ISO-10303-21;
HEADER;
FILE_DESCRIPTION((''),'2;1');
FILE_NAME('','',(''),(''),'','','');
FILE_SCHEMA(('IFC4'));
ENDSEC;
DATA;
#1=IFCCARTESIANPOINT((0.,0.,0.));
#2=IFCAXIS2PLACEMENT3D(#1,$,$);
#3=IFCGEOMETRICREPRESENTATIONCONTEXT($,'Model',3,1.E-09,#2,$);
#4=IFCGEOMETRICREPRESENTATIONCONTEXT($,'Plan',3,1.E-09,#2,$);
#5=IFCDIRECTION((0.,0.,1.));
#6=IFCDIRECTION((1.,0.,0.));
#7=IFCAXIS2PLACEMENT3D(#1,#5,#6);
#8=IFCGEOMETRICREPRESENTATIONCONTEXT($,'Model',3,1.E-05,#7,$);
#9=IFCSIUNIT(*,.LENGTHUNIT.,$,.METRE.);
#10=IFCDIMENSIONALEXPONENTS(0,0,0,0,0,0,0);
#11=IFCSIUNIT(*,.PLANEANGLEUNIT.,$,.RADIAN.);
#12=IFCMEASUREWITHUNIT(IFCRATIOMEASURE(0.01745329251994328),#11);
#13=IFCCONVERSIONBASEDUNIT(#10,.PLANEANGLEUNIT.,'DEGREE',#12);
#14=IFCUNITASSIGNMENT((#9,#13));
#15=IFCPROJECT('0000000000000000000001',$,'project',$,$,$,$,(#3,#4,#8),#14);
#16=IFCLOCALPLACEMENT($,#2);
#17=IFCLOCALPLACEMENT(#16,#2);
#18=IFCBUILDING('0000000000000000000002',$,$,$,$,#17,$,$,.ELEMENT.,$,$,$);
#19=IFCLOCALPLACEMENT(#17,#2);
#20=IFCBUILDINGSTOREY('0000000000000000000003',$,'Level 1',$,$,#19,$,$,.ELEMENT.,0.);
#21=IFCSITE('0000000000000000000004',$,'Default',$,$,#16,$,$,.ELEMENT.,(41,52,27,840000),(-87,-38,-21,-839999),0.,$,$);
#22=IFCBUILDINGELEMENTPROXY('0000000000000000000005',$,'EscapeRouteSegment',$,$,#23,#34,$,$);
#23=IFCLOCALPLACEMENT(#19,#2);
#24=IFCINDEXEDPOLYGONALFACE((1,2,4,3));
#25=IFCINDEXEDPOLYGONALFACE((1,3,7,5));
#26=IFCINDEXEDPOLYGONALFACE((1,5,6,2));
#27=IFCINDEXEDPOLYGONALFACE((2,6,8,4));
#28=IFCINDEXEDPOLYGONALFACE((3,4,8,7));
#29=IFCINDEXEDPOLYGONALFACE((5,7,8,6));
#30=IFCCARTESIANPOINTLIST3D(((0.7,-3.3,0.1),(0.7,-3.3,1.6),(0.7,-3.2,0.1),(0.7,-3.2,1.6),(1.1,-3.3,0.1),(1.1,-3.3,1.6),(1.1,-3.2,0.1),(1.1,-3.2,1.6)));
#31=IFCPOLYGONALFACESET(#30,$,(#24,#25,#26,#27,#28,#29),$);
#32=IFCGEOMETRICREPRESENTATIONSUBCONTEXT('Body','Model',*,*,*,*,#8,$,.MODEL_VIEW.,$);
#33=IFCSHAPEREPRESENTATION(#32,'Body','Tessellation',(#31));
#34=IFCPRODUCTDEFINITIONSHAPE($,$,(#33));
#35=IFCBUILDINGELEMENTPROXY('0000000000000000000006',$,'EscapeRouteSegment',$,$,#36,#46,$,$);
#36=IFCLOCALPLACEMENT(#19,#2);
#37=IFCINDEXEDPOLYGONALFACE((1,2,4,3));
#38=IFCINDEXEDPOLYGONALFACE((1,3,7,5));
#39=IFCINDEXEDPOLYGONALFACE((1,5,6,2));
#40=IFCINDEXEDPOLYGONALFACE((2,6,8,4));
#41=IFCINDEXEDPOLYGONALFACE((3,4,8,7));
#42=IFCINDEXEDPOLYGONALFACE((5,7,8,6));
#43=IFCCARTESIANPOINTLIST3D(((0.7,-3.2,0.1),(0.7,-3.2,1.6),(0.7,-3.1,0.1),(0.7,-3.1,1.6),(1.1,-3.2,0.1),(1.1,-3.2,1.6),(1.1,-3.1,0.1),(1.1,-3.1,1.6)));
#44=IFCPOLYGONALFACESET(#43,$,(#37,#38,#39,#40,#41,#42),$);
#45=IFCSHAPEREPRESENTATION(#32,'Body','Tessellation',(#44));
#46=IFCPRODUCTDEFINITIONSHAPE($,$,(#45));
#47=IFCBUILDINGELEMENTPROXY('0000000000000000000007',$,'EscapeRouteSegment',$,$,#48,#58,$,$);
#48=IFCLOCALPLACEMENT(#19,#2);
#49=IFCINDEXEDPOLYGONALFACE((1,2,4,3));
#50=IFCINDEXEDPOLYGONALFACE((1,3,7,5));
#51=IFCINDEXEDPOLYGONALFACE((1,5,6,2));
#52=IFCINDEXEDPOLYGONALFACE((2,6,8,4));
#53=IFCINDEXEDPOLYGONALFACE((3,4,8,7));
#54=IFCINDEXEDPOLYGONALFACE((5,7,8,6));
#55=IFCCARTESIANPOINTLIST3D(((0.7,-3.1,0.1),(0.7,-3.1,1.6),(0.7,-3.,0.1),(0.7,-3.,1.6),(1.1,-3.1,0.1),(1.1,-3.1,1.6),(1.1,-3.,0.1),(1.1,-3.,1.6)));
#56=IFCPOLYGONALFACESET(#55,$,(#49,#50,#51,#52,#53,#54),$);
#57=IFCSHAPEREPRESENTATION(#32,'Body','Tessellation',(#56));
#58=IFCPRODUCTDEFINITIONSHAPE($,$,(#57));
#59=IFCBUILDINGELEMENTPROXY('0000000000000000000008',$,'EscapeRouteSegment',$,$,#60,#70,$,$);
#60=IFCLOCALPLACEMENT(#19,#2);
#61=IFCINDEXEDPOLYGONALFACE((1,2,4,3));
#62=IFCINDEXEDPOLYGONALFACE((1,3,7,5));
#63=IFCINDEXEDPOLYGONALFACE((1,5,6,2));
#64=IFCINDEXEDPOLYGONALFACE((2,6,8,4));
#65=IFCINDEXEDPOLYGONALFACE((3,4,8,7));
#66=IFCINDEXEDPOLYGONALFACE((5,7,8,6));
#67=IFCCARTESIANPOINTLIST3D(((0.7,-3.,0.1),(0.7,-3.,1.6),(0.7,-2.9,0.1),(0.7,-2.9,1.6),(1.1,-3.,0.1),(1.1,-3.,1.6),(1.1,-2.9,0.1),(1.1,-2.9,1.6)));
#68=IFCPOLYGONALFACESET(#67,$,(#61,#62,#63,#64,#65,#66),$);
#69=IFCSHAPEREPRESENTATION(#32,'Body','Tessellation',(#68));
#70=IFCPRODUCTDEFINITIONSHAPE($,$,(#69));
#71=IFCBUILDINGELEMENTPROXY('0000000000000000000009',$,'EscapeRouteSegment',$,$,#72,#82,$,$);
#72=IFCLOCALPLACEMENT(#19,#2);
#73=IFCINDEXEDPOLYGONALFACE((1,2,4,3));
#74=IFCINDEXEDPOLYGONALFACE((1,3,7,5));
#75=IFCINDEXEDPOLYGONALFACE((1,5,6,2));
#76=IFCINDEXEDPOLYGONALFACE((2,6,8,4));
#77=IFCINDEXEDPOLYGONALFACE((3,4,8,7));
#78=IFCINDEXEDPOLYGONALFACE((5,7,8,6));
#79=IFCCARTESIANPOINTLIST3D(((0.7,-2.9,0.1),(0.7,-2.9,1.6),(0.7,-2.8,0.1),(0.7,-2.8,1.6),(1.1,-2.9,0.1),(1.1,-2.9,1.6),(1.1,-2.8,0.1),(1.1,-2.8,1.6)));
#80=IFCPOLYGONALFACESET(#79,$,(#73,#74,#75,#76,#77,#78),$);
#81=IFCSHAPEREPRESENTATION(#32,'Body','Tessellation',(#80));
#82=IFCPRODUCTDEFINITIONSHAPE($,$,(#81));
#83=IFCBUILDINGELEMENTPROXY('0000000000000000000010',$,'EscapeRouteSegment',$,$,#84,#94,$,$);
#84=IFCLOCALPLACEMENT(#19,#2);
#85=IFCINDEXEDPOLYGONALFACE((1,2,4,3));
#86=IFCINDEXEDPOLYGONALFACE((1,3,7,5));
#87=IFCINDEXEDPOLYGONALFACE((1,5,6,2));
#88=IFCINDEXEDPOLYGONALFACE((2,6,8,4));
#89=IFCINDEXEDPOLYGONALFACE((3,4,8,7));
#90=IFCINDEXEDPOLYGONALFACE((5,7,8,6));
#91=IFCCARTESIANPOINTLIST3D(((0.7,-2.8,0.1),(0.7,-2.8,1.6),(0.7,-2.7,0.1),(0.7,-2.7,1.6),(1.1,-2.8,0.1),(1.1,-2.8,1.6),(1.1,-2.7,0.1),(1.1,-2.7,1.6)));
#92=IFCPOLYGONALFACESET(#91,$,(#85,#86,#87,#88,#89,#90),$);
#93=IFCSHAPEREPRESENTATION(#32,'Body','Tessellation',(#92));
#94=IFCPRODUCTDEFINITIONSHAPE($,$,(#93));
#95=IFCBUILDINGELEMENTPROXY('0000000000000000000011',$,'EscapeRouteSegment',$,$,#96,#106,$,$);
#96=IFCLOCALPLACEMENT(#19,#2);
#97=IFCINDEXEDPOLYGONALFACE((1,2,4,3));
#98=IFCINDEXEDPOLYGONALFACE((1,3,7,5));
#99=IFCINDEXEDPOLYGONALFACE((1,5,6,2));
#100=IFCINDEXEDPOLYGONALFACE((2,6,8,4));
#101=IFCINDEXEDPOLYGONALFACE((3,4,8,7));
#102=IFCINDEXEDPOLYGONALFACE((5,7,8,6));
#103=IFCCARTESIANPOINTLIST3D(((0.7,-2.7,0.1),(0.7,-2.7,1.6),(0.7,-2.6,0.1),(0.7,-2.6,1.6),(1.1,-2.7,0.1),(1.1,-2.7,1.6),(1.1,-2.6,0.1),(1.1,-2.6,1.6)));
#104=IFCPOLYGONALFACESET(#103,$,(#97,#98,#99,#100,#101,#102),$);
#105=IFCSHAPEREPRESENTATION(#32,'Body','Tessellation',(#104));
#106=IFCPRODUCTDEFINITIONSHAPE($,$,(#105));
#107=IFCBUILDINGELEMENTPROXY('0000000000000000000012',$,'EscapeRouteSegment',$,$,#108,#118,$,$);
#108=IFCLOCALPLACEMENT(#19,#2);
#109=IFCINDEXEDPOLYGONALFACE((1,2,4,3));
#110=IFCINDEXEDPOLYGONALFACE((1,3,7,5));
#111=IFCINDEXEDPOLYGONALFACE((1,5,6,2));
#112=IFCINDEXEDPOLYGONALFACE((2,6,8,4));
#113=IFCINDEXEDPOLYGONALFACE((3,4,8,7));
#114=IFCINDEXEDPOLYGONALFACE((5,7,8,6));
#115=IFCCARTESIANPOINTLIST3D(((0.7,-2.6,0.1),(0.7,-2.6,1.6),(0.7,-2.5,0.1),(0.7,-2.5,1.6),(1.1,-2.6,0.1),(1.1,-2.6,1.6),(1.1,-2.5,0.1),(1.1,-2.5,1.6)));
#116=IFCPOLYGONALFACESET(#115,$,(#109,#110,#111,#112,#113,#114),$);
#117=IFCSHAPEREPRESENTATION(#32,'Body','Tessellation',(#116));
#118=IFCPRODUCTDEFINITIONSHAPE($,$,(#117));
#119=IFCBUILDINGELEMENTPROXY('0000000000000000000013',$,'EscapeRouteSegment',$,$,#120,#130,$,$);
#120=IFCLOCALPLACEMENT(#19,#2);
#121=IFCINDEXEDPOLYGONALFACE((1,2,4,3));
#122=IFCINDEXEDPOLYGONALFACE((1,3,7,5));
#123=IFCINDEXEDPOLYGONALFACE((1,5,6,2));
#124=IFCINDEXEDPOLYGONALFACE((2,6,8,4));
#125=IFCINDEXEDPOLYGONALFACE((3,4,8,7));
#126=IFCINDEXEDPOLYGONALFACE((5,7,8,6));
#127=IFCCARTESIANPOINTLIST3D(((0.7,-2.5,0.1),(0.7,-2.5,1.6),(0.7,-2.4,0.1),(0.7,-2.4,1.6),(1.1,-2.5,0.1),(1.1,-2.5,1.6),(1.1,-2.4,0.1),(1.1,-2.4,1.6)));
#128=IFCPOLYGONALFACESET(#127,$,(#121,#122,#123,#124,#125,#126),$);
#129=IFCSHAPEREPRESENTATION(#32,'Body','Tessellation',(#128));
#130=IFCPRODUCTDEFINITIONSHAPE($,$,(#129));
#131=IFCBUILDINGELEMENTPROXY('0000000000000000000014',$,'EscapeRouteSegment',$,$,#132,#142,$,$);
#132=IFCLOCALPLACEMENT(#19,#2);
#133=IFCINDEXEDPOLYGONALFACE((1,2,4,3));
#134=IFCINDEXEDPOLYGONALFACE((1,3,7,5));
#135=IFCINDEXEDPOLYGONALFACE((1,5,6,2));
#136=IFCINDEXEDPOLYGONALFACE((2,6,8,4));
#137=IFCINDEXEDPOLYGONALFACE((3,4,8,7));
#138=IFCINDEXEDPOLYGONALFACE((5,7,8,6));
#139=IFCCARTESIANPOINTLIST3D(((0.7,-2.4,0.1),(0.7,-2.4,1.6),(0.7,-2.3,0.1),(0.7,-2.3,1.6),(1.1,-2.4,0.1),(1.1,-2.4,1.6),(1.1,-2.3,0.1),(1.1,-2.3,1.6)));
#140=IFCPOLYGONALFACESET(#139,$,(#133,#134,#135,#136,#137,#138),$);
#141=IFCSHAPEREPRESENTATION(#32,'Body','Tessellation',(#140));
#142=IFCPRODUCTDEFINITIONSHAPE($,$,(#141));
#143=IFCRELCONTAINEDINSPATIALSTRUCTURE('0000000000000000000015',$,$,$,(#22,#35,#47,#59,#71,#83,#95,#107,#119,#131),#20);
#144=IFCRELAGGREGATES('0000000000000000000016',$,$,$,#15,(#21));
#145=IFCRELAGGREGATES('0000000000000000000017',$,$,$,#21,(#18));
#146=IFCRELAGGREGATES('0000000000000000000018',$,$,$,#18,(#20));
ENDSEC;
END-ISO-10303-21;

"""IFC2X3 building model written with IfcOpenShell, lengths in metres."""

from ifc_helpers import new_model, entity, si_unit, converted_unit, frame, origin, origin_with_axes, place, context, subcontext, project, spatial, polyline, outline, extrude, element, save


model = new_model("IFC2X3")

# Units and contexts
model_context_1 = context("Model", 3, precision=1e-09, world=origin())
plan_context = context("Plan", 3, precision=1e-09, world=origin())
model_context_2 = context("Model", 3, precision=1e-05, world=origin_with_axes())
body_context = subcontext(model_context_2, "Body", "Model", "MODEL_VIEW")
ifc_project = project(units=[si_unit("LENGTHUNIT", "METRE"), converted_unit("PLANEANGLEUNIT", "DEGREE", entity("IfcRatioMeasure", 0.01745329251994328), si_unit("PLANEANGLEUNIT", "RADIAN"), dimensions=[0, 0, 0, 0, 0, 0, 0])], contexts=[model_context_1, plan_context, model_context_2])

# Site, building, storey
site_placement = place(None, origin())
site = spatial("IfcSite", under=ifc_project, at=site_placement, Name="Default", CompositionType="ELEMENT", RefLatitude=(41, 52, 27, 840000), RefLongitude=(-87, -38, -21, -839999), RefElevation=0.0)
building_placement = place(site_placement, origin())
building = spatial("IfcBuilding", under=site, at=building_placement, CompositionType="ELEMENT")
storey_placement = place(building_placement, origin())
storey = spatial("IfcBuildingStorey", under=building, at=storey_placement, Name="Level 1", CompositionType="ELEMENT", Elevation=0.0)

# Building element proxies
proxy_1_placement = place(storey_placement, frame((0.9, -3.3, 0.1), z_axis=(0.0, 0.0, 1.0), x_axis=(0.0, 1.0, 0.0)))
element("IfcBuildingElementProxy", 1, at=proxy_1_placement, inside=storey, Name="EscapeRouteSegment", context=body_context, shape_type="SweptSolid", body=[
    extrude(outline(polyline([(0.0, -0.2), (0.0, 0.2), (0.1, 0.2), (0.1, -0.2), (0.0, -0.2)])), origin_with_axes(), (0.0, 0.0, 1.0), 1.5),
])
proxy_2_placement = place(storey_placement, frame((0.9, -3.2, 0.1), z_axis=(0.0, 0.0, 1.0), x_axis=(0.0, 1.0, 0.0)))
element("IfcBuildingElementProxy", 2, at=proxy_2_placement, inside=storey, Name="EscapeRouteSegment", context=body_context, shape_type="SweptSolid", body=[
    extrude(outline(polyline([(0.0, -0.2), (0.0, 0.2), (0.1, 0.2), (0.1, -0.2), (0.0, -0.2)])), origin_with_axes(), (0.0, 0.0, 1.0), 1.5),
])
for number, where, z_axis, x_axis, name in (
    (3, (0.9, -3.1, 0.1), (0.0, 0.0, 1.0), (0.0, 1.0, 0.0), "EscapeRouteSegment"),
    (4, (0.9, -3.0, 0.1), (0.0, 0.0, 1.0), (0.0, 1.0, 0.0), "EscapeRouteSegment"),
):
    element("IfcBuildingElementProxy", number, at=place(storey_placement, frame(where, z_axis=z_axis, x_axis=x_axis)), inside=storey, Name=name, context=body_context, shape_type="SweptSolid", body=[
        extrude(outline(polyline([(0.0, -0.2), (0.0, 0.2), (0.1, 0.2), (0.1, -0.2), (0.0, -0.2)])), origin_with_axes(), (0.0, 0.0, 1.0), 1.5),
    ])
proxy_3_placement = place(storey_placement, frame((0.9, -2.9, 0.1), z_axis=(0.0, 0.0, 1.0), x_axis=(0.0, 1.0, 0.0)))
element("IfcBuildingElementProxy", 5, at=proxy_3_placement, inside=storey, Name="EscapeRouteSegment", context=body_context, shape_type="SweptSolid", body=[
    extrude(outline(polyline([(0.0, -0.2), (0.0, 0.2), (0.1, 0.2), (0.1, -0.2), (0.0, -0.2)])), origin_with_axes(), (0.0, 0.0, 1.0), 1.5),
])
proxy_4_placement = place(storey_placement, frame((0.9, -2.8, 0.1), z_axis=(0.0, 0.0, 1.0), x_axis=(0.0, 1.0, 0.0)))
element("IfcBuildingElementProxy", 6, at=proxy_4_placement, inside=storey, Name="EscapeRouteSegment", context=body_context, shape_type="SweptSolid", body=[
    extrude(outline(polyline([(0.0, -0.2), (0.0, 0.2), (0.1, 0.2), (0.1, -0.2), (0.0, -0.2)])), origin_with_axes(), (0.0, 0.0, 1.0), 1.5),
])
proxy_5_placement = place(storey_placement, frame((0.9, -2.7, 0.1), z_axis=(0.0, 0.0, 1.0), x_axis=(0.0, 1.0, 0.0)))
element("IfcBuildingElementProxy", 7, at=proxy_5_placement, inside=storey, Name="EscapeRouteSegment", context=body_context, shape_type="SweptSolid", body=[
    extrude(outline(polyline([(0.0, -0.2), (0.0, 0.2), (0.1, 0.2), (0.1, -0.2), (0.0, -0.2)])), origin_with_axes(), (0.0, 0.0, 1.0), 1.5),
])
for number, where, z_axis, x_axis, name in (
    (8, (0.9, -2.6, 0.1), (0.0, 0.0, 1.0), (0.0, 1.0, 0.0), "EscapeRouteSegment"),
    (9, (0.9, -2.5, 0.1), (0.0, 0.0, 1.0), (0.0, 1.0, 0.0), "EscapeRouteSegment"),
):
    element("IfcBuildingElementProxy", number, at=place(storey_placement, frame(where, z_axis=z_axis, x_axis=x_axis)), inside=storey, Name=name, context=body_context, shape_type="SweptSolid", body=[
        extrude(outline(polyline([(0.0, -0.2), (0.0, 0.2), (0.1, 0.2), (0.1, -0.2), (0.0, -0.2)])), origin_with_axes(), (0.0, 0.0, 1.0), 1.5),
    ])
proxy_6_placement = place(storey_placement, frame((0.9, -2.4, 0.1), z_axis=(0.0, 0.0, 1.0), x_axis=(0.0, 1.0, 0.0)))
element("IfcBuildingElementProxy", 10, at=proxy_6_placement, inside=storey, Name="EscapeRouteSegment", context=body_context, shape_type="SweptSolid", body=[
    extrude(outline(polyline([(0.0, -0.2), (0.0, 0.2), (0.1, 0.2), (0.1, -0.2), (0.0, -0.2)])), origin_with_axes(), (0.0, 0.0, 1.0), 1.5),
])

save(model, "model.ifc")
